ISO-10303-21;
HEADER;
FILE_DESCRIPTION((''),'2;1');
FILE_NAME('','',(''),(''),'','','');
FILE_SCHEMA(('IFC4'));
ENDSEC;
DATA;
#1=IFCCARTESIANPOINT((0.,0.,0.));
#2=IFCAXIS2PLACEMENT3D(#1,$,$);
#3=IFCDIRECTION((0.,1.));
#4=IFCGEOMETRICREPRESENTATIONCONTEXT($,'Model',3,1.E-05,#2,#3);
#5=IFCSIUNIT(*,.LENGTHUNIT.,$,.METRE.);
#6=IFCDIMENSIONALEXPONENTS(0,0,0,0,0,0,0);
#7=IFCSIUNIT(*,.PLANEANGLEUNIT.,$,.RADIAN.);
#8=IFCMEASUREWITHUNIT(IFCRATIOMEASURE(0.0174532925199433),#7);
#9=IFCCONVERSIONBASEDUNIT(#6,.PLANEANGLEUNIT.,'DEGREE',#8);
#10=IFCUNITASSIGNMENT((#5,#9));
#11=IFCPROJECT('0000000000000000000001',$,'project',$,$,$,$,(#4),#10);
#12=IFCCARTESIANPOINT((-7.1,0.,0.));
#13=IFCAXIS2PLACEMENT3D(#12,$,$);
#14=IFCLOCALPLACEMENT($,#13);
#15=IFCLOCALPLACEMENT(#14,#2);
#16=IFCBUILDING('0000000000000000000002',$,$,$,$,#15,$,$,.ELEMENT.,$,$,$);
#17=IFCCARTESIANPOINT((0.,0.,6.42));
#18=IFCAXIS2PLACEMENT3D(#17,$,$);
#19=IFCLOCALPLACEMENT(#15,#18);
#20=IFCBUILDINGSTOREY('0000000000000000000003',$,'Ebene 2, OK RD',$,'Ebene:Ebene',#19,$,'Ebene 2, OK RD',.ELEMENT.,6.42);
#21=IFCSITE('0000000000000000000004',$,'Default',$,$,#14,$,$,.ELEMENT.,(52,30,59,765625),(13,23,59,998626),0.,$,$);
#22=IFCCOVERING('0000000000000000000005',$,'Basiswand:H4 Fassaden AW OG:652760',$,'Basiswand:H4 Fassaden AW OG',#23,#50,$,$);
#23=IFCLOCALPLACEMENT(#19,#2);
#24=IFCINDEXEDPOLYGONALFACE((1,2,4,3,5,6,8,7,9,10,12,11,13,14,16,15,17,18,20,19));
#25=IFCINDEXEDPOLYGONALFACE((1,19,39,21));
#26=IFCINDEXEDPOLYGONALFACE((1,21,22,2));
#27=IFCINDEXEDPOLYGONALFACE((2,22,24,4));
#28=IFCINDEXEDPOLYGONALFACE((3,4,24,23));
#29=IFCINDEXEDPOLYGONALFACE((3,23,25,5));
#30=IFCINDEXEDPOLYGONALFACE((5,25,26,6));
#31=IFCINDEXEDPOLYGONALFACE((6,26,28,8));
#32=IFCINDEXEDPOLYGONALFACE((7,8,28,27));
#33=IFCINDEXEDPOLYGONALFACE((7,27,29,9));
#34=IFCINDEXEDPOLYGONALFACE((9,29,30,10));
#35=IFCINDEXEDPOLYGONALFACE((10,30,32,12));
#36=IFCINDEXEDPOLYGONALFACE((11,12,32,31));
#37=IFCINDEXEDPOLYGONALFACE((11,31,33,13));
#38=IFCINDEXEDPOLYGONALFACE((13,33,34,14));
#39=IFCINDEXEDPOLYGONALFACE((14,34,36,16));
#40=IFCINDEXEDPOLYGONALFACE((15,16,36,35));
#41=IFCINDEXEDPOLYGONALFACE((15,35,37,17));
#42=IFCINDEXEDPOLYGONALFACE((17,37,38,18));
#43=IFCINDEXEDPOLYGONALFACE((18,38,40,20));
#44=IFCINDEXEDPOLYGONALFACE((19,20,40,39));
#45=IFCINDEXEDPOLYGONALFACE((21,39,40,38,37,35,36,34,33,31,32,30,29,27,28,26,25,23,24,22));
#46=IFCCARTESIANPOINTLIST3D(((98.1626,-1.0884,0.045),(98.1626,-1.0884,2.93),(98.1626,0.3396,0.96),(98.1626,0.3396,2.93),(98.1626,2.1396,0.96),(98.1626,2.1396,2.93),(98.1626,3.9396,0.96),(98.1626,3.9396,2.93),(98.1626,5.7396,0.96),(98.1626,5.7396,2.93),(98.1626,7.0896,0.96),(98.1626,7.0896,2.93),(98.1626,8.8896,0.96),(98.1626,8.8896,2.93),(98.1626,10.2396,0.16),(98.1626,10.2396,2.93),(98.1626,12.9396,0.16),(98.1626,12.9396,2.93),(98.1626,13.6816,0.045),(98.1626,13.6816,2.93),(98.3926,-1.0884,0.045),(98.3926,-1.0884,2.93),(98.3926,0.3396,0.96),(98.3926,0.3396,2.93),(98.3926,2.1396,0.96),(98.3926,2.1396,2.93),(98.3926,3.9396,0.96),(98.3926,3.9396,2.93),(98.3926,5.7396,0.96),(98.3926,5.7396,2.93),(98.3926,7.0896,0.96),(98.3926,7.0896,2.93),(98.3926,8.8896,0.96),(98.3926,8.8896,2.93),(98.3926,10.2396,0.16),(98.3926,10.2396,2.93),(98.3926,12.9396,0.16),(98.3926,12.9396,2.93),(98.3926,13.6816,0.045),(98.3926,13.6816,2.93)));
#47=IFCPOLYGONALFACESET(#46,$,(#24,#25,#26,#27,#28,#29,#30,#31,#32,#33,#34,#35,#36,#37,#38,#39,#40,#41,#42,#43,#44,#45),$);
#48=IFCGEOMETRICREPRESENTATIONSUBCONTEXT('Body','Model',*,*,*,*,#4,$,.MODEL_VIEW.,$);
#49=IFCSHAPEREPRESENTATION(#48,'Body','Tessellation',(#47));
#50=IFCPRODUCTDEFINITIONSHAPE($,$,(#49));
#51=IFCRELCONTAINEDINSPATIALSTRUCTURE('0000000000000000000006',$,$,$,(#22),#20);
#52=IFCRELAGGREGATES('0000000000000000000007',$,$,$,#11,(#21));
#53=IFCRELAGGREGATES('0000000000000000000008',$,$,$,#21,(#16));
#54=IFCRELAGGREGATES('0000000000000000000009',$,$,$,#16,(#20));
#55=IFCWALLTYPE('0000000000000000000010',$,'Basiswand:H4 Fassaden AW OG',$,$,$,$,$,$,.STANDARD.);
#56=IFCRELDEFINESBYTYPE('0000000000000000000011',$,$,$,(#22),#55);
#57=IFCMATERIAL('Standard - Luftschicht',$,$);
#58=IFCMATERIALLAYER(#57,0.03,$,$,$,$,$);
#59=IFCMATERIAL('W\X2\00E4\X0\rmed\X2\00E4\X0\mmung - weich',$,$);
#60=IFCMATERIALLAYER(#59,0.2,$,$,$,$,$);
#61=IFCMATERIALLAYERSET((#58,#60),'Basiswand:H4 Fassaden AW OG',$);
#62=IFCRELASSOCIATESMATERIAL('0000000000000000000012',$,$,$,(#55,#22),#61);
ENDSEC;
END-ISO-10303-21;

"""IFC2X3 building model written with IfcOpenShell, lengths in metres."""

from ifc_helpers import new_model, entity, si_unit, converted_unit, direction, frame, frame_2d, origin, place, context, subcontext, project, spatial, rectangle, extrude, material, layer, layer_set, layer_usage, type_object, element, save


model = new_model("IFC2X3")

# Units and contexts
model_context = context("Model", 3, precision=1e-05, world=origin(), true_north=direction((0.0, 1.0)))
body_context = subcontext(model_context, "Body", "Model", "MODEL_VIEW")
ifc_project = project(units=[si_unit("LENGTHUNIT", "METRE"), converted_unit("PLANEANGLEUNIT", "DEGREE", entity("IfcRatioMeasure", 0.0174532925199433), si_unit("PLANEANGLEUNIT", "RADIAN"), dimensions=[0, 0, 0, 0, 0, 0, 0])], contexts=[model_context])

# Site, building, storey
site_placement = place(None, frame((-7.1, 0.0, 0.0)))
site = spatial("IfcSite", under=ifc_project, at=site_placement, Name="Default", CompositionType="ELEMENT", RefLatitude=(52, 30, 59, 765625), RefLongitude=(13, 23, 59, 998626), RefElevation=0.0)
building_placement = place(site_placement, origin())
building = spatial("IfcBuilding", under=site, at=building_placement, CompositionType="ELEMENT")
storey_placement = place(building_placement, frame((0.0, 0.0, 6.42)))
storey = spatial("IfcBuildingStorey", under=building, at=storey_placement, Name="Ebene 2, OK RD", ObjectType="Ebene:Ebene", LongName="Ebene 2, OK RD", CompositionType="ELEMENT", Elevation=6.42)

# Shared definitions
ifc_material_1 = material(Name="Standard - Luftschicht")
ifc_material_2 = material(Name="Wärmedämmung - weich")

# Shared definitions
ifc_layer_1 = layer(ifc_material_1, 0.03)
ifc_layer_2 = layer(ifc_material_2, 0.2)
ifc_layer_set_1 = layer_set([ifc_layer_1, ifc_layer_2], Name="Basiswand:H4 Fassaden AW OG")
wall_type_1 = type_object("IfcWallType", Name="Basiswand:H4 Fassaden AW OG", PredefinedType="STANDARD", material=ifc_layer_set_1)

# Covering, openings
ifc_layer_usage_1 = layer_usage(ifc_layer_set_1, "AXIS2", "NEGATIVE", 0.115)
covering_placement = place(storey_placement, frame((98.2776, -1.0884, 0.045), z_axis=(0.0, 0.0, 1.0), x_axis=(0.0, 1.0, 0.0)))
covering = element("IfcCovering", 1, at=covering_placement, inside=storey, type_object=wall_type_1, material=ifc_layer_usage_1, Name="Basiswand:H4 Fassaden AW OG:652760", ObjectType="Basiswand:H4 Fassaden AW OG", context=body_context, shape_type="SweptSolid", body=[
    extrude(rectangle(XDim=14.77, YDim=0.23, at=frame_2d((7.385, 0.0), x_axis=(-1.0, 0.0))), origin(), (0.0, 0.0, 1.0), 2.885),
])
opening_1_placement = place(covering_placement, origin())
element("IfcOpeningElement", 2, at=opening_1_placement, cuts=covering, ObjectType="Opening", context=body_context, shape_type="SweptSolid", body=[
    extrude(rectangle(XDim=2.8, YDim=2.7, at=frame_2d((0.0, 0.0), x_axis=(0.0, 1.0))), frame((12.678, -0.2674, 1.515), z_axis=(0.0, 1.0, 0.0), x_axis=(-1.0, 0.0, 0.0)), (0.0, 0.0, 1.0), 0.5348),
])
opening_2_placement = place(covering_placement, frame((3.228, 0.115, 0.915)))
element("IfcOpeningElement", 3, at=opening_2_placement, cuts=covering, ObjectType="Opening", context=body_context, shape_type="SweptSolid", body=[
    extrude(rectangle(XDim=1.97, YDim=1.8, at=frame_2d((0.985, 0.9), x_axis=(1.0, 0.0))), frame((0.0, 0.0, 0.0), z_axis=(0.0, -1.0, 0.0), x_axis=(0.0, 0.0, 1.0)), (0.0, 0.0, 1.0), 0.23),
])
opening_3_placement = place(covering_placement, frame((9.978, 0.115, 0.915)))
element("IfcOpeningElement", 4, at=opening_3_placement, cuts=covering, ObjectType="Opening", context=body_context, shape_type="SweptSolid", body=[
    extrude(rectangle(XDim=1.97, YDim=1.8, at=frame_2d((0.985, 0.9), x_axis=(1.0, 0.0))), frame((0.0, 0.0, 0.0), z_axis=(0.0, -1.0, 0.0), x_axis=(0.0, 0.0, 1.0)), (0.0, 0.0, 1.0), 0.23),
])
opening_4_placement = place(covering_placement, frame((6.828, 0.115, 0.915)))
element("IfcOpeningElement", 5, at=opening_4_placement, cuts=covering, ObjectType="Opening", context=body_context, shape_type="SweptSolid", body=[
    extrude(rectangle(XDim=1.97, YDim=1.8, at=frame_2d((0.985, 0.9), x_axis=(1.0, 0.0))), frame((0.0, 0.0, 0.0), z_axis=(0.0, -1.0, 0.0), x_axis=(0.0, 0.0, 1.0)), (0.0, 0.0, 1.0), 0.23),
])

save(model, "model.ifc")
